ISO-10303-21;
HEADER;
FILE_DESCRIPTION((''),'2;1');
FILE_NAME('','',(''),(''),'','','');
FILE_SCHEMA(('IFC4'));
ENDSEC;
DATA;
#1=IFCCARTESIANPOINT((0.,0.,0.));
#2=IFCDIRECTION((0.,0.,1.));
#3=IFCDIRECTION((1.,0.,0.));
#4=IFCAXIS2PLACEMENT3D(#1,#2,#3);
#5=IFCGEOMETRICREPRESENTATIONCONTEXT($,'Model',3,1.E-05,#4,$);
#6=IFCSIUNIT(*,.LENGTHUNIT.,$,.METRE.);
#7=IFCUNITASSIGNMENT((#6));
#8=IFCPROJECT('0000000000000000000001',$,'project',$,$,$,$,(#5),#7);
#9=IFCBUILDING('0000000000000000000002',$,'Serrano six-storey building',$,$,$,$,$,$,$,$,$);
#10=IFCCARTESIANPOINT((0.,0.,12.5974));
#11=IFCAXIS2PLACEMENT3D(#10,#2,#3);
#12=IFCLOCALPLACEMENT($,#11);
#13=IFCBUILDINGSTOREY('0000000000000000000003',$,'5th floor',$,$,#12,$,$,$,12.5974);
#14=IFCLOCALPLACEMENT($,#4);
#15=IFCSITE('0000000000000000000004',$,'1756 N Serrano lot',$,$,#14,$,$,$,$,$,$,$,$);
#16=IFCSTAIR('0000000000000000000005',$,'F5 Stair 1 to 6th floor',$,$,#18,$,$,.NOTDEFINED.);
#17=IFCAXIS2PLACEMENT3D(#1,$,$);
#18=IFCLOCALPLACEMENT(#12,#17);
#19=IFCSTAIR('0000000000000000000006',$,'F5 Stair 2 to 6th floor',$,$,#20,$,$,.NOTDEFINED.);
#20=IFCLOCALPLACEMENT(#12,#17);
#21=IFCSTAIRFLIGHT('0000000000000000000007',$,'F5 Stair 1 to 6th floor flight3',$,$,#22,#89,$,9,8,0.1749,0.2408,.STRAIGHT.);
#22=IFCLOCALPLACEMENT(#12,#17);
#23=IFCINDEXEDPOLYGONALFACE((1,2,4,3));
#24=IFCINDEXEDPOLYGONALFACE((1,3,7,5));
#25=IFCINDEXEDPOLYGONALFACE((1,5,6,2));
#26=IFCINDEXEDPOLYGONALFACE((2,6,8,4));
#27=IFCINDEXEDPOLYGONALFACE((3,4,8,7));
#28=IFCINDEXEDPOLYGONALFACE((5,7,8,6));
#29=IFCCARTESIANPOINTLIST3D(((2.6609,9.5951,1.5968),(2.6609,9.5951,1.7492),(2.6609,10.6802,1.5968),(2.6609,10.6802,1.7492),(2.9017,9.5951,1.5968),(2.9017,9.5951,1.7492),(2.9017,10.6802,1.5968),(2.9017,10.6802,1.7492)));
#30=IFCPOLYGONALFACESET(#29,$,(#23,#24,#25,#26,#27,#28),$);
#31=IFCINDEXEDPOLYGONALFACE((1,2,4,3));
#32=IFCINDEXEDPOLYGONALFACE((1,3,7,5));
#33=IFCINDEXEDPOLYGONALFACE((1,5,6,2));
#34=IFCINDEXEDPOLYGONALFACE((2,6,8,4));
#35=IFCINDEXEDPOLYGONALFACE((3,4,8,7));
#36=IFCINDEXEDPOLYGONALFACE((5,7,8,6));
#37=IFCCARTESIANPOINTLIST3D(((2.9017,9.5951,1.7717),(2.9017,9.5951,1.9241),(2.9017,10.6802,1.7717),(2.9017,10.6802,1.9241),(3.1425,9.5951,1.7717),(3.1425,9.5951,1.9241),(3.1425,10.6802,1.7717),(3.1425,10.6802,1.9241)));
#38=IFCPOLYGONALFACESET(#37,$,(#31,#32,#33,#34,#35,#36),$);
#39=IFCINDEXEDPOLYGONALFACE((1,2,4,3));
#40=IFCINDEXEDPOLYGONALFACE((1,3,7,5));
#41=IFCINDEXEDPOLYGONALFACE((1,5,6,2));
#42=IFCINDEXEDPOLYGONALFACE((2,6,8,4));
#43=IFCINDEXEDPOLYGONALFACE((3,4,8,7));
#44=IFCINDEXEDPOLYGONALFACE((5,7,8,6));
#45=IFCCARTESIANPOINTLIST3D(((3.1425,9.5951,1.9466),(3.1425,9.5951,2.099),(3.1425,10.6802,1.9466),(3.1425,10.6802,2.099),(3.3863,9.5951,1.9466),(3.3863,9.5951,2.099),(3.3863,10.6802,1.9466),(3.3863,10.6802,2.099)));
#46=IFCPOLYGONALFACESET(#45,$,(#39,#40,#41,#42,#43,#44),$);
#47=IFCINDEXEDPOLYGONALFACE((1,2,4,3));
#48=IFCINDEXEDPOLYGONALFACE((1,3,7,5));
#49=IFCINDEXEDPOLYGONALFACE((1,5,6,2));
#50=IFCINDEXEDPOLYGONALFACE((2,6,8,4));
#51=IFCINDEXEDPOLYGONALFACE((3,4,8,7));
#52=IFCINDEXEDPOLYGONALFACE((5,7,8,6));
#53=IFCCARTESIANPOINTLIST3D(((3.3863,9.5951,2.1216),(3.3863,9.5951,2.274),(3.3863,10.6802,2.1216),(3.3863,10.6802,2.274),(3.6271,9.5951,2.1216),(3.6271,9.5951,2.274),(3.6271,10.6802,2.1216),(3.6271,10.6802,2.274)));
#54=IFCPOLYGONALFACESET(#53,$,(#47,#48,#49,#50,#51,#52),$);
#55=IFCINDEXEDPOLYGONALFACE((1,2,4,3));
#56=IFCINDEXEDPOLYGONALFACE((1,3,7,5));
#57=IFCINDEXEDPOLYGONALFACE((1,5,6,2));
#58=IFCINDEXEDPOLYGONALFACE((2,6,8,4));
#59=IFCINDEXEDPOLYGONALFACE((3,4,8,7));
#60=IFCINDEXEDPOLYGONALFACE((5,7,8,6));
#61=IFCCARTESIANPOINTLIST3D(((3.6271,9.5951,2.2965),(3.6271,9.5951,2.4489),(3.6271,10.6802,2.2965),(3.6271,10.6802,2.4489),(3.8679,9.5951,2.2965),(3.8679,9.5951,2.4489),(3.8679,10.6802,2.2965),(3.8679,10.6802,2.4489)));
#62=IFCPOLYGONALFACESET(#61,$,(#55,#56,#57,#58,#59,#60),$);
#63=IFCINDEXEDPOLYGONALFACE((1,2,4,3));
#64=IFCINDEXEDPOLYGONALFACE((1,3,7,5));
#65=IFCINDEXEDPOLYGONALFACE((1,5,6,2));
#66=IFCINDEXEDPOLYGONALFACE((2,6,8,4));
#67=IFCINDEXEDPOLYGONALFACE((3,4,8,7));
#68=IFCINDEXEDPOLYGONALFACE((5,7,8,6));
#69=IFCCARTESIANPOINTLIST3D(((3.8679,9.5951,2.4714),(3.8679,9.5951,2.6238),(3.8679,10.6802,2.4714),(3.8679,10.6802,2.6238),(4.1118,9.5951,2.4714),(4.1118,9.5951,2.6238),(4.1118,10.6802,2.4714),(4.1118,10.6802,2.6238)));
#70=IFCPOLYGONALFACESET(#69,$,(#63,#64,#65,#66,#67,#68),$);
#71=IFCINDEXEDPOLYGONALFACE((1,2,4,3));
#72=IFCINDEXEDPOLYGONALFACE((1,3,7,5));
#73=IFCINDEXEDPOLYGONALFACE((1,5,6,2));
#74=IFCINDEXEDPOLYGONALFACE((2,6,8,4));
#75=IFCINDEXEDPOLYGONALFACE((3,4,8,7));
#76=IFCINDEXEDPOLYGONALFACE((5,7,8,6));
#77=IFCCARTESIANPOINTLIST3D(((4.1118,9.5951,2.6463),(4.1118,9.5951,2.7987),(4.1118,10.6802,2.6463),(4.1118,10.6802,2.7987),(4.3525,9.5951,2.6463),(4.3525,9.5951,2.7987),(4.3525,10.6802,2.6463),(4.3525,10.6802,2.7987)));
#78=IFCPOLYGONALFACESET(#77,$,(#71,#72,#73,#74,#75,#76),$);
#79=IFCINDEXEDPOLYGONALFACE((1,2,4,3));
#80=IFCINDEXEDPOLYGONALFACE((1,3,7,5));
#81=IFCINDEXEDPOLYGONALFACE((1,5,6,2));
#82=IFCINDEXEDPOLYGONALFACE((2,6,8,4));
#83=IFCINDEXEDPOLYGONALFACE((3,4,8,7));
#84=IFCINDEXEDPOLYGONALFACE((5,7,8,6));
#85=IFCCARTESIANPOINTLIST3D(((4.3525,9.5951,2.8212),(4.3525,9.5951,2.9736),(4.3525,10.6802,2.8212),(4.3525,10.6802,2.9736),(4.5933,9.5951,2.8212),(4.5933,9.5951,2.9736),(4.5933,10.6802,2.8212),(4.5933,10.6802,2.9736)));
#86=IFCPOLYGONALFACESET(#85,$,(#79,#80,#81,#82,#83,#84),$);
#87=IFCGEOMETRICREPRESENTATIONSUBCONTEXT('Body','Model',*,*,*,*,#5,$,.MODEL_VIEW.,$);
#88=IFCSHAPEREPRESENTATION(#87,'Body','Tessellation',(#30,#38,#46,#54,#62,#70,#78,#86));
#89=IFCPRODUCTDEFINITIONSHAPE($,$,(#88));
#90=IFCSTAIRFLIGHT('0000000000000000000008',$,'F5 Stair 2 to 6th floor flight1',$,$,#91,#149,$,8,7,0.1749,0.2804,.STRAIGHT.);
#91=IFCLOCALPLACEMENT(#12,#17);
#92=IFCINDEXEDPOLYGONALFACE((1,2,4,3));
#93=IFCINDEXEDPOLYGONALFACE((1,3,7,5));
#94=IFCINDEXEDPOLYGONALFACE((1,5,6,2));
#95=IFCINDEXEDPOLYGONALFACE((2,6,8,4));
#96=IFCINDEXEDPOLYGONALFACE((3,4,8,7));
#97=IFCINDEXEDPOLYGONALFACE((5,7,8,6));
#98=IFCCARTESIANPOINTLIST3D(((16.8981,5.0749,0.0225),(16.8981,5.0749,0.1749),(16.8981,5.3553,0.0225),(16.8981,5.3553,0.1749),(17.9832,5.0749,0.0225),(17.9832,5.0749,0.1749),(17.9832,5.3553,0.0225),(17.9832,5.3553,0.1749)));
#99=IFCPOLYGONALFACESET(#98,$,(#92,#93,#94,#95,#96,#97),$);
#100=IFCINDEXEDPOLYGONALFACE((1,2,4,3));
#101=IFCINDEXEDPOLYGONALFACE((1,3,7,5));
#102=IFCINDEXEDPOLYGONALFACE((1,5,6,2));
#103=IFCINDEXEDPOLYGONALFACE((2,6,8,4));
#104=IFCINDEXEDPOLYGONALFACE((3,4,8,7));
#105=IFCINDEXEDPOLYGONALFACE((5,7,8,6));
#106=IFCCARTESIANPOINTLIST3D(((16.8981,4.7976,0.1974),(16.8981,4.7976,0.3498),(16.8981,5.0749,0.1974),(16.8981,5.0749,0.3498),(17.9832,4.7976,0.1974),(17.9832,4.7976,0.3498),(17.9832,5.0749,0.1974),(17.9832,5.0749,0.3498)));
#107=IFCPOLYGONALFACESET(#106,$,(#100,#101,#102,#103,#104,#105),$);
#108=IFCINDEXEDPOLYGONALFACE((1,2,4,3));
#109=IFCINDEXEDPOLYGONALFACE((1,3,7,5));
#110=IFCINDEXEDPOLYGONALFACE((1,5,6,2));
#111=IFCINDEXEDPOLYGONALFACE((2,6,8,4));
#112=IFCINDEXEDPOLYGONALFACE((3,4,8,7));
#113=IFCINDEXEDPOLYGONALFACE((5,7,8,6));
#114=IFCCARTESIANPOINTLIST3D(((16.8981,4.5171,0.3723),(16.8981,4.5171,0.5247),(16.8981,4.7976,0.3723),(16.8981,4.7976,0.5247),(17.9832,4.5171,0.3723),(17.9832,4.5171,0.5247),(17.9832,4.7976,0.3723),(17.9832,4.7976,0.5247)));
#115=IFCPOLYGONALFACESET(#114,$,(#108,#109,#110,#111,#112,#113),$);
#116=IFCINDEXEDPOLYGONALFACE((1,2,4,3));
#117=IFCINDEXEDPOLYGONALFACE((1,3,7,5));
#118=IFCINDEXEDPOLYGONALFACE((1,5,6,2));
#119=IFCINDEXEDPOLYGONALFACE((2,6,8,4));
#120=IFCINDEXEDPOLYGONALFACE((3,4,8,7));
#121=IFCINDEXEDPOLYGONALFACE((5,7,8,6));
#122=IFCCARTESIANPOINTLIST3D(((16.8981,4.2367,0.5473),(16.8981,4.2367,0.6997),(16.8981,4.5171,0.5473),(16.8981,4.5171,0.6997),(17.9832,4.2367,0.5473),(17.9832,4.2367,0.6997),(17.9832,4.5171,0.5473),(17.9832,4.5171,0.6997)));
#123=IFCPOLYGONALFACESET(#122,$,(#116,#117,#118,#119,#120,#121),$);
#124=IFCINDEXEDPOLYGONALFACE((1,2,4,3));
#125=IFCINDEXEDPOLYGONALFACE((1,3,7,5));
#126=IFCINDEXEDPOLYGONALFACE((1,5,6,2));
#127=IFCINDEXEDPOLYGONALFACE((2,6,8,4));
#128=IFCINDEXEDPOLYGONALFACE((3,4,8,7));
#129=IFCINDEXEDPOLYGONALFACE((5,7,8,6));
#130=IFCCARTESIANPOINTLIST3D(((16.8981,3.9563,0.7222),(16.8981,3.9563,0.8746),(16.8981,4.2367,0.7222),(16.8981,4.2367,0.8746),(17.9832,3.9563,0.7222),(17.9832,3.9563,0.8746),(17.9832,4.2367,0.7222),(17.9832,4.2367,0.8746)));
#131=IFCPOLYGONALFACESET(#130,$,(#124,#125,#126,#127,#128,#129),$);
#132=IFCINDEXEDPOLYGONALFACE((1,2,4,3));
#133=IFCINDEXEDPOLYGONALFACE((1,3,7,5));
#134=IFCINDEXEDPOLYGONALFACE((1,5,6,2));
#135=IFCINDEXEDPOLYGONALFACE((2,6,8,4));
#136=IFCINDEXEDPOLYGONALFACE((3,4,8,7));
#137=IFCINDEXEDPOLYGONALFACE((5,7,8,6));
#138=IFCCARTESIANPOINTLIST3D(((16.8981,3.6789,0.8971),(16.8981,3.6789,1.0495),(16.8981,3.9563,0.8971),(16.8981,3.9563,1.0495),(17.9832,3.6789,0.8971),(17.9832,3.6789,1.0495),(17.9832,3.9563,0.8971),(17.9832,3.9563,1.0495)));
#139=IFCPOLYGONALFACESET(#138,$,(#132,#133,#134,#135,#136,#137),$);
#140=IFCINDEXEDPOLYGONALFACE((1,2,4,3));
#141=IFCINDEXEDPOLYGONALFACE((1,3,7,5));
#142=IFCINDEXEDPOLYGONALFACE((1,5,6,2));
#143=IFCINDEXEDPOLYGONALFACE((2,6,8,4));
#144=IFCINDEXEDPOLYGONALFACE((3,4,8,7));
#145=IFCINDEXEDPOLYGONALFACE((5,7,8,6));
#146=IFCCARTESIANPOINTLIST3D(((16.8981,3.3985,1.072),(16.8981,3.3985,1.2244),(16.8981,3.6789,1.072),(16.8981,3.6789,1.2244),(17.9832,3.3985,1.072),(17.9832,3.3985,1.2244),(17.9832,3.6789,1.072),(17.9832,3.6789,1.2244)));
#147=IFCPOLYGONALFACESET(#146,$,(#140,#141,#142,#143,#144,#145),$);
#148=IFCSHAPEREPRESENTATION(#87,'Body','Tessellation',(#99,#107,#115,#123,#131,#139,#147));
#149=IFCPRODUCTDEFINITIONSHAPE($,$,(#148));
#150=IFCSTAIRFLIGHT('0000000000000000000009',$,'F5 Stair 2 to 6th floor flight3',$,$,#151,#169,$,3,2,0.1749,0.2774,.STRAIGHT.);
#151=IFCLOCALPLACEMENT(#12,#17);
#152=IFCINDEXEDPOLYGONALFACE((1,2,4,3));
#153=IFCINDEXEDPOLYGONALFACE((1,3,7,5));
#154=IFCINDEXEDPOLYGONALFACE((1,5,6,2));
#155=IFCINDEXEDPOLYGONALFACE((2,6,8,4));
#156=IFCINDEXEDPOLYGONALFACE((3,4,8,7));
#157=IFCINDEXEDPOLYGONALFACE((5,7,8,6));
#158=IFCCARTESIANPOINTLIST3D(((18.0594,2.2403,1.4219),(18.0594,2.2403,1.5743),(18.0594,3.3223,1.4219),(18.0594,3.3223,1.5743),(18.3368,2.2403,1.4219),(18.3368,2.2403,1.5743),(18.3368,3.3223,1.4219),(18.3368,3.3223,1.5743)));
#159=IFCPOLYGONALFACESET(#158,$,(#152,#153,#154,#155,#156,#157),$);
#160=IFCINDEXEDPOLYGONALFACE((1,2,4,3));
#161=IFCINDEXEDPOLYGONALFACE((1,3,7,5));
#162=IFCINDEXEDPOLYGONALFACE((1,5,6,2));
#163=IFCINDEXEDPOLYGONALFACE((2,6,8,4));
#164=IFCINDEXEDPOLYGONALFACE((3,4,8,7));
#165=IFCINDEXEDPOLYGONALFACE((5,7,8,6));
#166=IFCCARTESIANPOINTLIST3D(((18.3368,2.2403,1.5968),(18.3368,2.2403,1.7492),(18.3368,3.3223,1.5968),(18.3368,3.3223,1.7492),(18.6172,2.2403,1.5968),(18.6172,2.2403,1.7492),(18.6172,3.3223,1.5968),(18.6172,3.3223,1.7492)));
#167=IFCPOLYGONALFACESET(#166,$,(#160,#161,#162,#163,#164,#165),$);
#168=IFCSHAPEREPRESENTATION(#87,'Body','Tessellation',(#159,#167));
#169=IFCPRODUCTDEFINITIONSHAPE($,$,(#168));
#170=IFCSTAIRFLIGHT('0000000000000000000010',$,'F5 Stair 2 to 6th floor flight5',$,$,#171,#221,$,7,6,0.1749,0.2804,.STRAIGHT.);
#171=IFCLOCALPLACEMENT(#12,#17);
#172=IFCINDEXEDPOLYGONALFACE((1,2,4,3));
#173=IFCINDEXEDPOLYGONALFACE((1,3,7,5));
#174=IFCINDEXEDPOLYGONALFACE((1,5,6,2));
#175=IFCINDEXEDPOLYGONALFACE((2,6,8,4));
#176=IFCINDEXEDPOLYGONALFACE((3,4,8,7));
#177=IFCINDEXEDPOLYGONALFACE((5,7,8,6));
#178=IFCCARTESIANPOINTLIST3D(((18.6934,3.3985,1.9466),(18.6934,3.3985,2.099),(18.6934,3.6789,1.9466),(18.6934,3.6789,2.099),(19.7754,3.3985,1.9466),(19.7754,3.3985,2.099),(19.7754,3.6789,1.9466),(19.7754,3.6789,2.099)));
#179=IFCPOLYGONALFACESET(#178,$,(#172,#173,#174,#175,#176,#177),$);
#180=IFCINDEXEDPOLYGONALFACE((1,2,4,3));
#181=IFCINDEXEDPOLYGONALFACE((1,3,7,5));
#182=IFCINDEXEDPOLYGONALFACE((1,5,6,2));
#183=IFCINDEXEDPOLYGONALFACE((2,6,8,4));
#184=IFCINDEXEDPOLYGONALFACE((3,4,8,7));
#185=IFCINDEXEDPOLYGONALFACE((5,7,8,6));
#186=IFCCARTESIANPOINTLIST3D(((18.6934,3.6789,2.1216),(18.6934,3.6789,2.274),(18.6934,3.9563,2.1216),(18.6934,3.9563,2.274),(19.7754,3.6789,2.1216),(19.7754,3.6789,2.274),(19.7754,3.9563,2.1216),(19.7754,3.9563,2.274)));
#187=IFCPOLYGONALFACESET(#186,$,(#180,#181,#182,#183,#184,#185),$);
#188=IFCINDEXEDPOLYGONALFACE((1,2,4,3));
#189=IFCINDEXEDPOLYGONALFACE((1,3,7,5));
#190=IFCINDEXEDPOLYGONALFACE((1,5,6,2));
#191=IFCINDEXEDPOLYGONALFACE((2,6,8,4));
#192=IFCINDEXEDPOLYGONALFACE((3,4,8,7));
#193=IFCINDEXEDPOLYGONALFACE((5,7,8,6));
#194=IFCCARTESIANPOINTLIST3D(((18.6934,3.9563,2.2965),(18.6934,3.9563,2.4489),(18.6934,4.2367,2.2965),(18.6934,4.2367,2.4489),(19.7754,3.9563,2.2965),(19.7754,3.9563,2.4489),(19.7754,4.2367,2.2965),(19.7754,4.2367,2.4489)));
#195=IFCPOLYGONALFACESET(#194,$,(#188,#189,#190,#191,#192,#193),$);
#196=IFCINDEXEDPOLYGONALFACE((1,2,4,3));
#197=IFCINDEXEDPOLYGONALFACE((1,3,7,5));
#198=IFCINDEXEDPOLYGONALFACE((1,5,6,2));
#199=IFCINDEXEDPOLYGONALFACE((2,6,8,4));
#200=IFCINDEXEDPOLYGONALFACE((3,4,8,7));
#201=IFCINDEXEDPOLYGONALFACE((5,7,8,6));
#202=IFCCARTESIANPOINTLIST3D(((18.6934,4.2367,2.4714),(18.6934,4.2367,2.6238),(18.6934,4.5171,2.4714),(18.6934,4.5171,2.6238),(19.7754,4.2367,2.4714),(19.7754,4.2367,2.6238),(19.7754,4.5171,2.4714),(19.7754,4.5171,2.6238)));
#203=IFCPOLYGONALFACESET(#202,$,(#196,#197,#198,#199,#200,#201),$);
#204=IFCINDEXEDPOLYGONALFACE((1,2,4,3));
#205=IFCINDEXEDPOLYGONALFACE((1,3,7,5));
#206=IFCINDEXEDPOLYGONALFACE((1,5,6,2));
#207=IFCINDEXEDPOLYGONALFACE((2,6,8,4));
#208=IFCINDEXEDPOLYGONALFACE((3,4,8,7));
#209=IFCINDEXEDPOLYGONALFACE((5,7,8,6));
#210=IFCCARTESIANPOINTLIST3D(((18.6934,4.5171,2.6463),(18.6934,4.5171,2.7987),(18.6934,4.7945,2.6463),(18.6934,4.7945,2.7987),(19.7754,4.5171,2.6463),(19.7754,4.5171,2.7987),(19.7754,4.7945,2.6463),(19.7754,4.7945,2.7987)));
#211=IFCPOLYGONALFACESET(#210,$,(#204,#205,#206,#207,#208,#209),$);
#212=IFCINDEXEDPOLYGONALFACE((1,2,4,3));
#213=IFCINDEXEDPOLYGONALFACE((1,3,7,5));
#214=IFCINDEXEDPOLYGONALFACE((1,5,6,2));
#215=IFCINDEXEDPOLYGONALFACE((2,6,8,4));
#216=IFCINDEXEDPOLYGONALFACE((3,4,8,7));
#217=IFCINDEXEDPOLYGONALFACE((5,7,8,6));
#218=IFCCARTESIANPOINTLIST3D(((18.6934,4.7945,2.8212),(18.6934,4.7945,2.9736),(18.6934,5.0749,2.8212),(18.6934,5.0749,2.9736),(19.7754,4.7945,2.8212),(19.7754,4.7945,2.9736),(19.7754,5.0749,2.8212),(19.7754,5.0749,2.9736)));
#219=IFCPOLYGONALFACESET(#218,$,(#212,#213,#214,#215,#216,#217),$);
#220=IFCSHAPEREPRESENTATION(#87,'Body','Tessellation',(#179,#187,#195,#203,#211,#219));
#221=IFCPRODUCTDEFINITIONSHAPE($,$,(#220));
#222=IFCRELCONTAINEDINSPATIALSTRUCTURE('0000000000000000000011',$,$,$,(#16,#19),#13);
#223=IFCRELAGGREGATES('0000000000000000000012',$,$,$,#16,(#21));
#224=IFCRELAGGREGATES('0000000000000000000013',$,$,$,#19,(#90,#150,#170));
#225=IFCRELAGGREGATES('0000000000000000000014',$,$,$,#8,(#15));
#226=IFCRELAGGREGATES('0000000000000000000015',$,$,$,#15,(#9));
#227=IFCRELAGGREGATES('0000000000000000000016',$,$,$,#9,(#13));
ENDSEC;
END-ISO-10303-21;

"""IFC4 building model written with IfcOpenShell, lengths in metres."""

from ifc_helpers import new_model, si_unit, frame, origin_with_axes, place, context, subcontext, project, spatial, polyline, outline, extrude, element, aggregate, save


model = new_model("IFC4")

# Units and contexts
model_context = context("Model", 3, precision=1e-05, world=origin_with_axes())
body_context = subcontext(model_context, "Body", "Model", "MODEL_VIEW")
ifc_project = project(units=[si_unit("LENGTHUNIT", "METRE")], contexts=[model_context])

# Site, building, storey
site_placement = place(None, origin_with_axes())
site = spatial("IfcSite", under=ifc_project, at=site_placement, Name="1756 N Serrano lot")
building = spatial("IfcBuilding", under=site, Name="Serrano six-storey building")
storey_placement = place(None, frame((0.0, 0.0, 12.5974), z_axis=(0.0, 0.0, 1.0), x_axis=(1.0, 0.0, 0.0)))
storey = spatial("IfcBuildingStorey", under=building, at=storey_placement, Name="5th floor", Elevation=12.5974)

# Stair
stair_1 = element("IfcStair", 1, inside=storey, Name="F5 Stair 1 to 6th floor", PredefinedType="NOTDEFINED")

# Stair
stair_2 = element("IfcStair", 2, inside=storey, Name="F5 Stair 2 to 6th floor", PredefinedType="NOTDEFINED")

# Stair flights
stair_flight_1_placement = place(None, origin_with_axes())
stair_flight_1 = element("IfcStairFlight", 3, at=stair_flight_1_placement, Name="F5 Stair 1 to 6th floor flight3", NumberOfRisers=9, NumberOfTreads=8, PredefinedType="STRAIGHT", RiserHeight=0.1749, TreadLength=0.2408, context=body_context, shape_type="SweptSolid", body=[
    extrude(outline(polyline([(2.9017, 9.5951), (2.9017, 10.6802), (2.6609, 10.6802), (2.6609, 9.5951), (2.9017, 9.5951)])), frame((0.0, 0.0, 14.1942)), (0.0, 0.0, 1.0), 0.1524),
    extrude(outline(polyline([(3.1425, 9.5951), (3.1425, 10.6802), (2.9017, 10.6802), (2.9017, 9.5951), (3.1425, 9.5951)])), frame((0.0, 0.0, 14.3691)), (0.0, 0.0, 1.0), 0.1524),
    extrude(outline(polyline([(3.3863, 9.5951), (3.3863, 10.6802), (3.1425, 10.6802), (3.1425, 9.5951), (3.3863, 9.5951)])), frame((0.0, 0.0, 14.544)), (0.0, 0.0, 1.0), 0.1524),
    extrude(outline(polyline([(3.6271, 9.5951), (3.6271, 10.6802), (3.3863, 10.6802), (3.3863, 9.5951), (3.6271, 9.5951)])), frame((0.0, 0.0, 14.719)), (0.0, 0.0, 1.0), 0.1524),
    extrude(outline(polyline([(3.8679, 9.5951), (3.8679, 10.6802), (3.6271, 10.6802), (3.6271, 9.5951), (3.8679, 9.5951)])), frame((0.0, 0.0, 14.8939)), (0.0, 0.0, 1.0), 0.1524),
    extrude(outline(polyline([(4.1118, 9.5951), (4.1118, 10.6802), (3.8679, 10.6802), (3.8679, 9.5951), (4.1118, 9.5951)])), frame((0.0, 0.0, 15.0688)), (0.0, 0.0, 1.0), 0.1524),
    extrude(outline(polyline([(4.3525, 9.5951), (4.3525, 10.6802), (4.1118, 10.6802), (4.1118, 9.5951), (4.3525, 9.5951)])), frame((0.0, 0.0, 15.2437)), (0.0, 0.0, 1.0), 0.1524),
    extrude(outline(polyline([(4.5933, 9.5951), (4.5933, 10.6802), (4.3525, 10.6802), (4.3525, 9.5951), (4.5933, 9.5951)])), frame((0.0, 0.0, 15.4186)), (0.0, 0.0, 1.0), 0.1524),
])
aggregate(stair_1, [stair_flight_1])
stair_flight_2_placement = place(None, origin_with_axes())
stair_flight_2 = element("IfcStairFlight", 4, at=stair_flight_2_placement, Name="F5 Stair 2 to 6th floor flight1", NumberOfRisers=8, NumberOfTreads=7, PredefinedType="STRAIGHT", RiserHeight=0.1749, TreadLength=0.2804, context=body_context, shape_type="SweptSolid", body=[
    extrude(outline(polyline([(17.9832, 5.0749), (17.9832, 5.3553), (16.8981, 5.3553), (16.8981, 5.0749), (17.9832, 5.0749)])), frame((0.0, 0.0, 12.6199)), (0.0, 0.0, 1.0), 0.1524),
    extrude(outline(polyline([(17.9832, 4.7976), (17.9832, 5.0749), (16.8981, 5.0749), (16.8981, 4.7976), (17.9832, 4.7976)])), frame((0.0, 0.0, 12.7948)), (0.0, 0.0, 1.0), 0.1524),
    extrude(outline(polyline([(17.9832, 4.5171), (17.9832, 4.7976), (16.8981, 4.7976), (16.8981, 4.5171), (17.9832, 4.5171)])), frame((0.0, 0.0, 12.9697)), (0.0, 0.0, 1.0), 0.1524),
    extrude(outline(polyline([(17.9832, 4.2367), (17.9832, 4.5171), (16.8981, 4.5171), (16.8981, 4.2367), (17.9832, 4.2367)])), frame((0.0, 0.0, 13.1447)), (0.0, 0.0, 1.0), 0.1524),
    extrude(outline(polyline([(17.9832, 3.9563), (17.9832, 4.2367), (16.8981, 4.2367), (16.8981, 3.9563), (17.9832, 3.9563)])), frame((0.0, 0.0, 13.3196)), (0.0, 0.0, 1.0), 0.1524),
    extrude(outline(polyline([(17.9832, 3.6789), (17.9832, 3.9563), (16.8981, 3.9563), (16.8981, 3.6789), (17.9832, 3.6789)])), frame((0.0, 0.0, 13.4945)), (0.0, 0.0, 1.0), 0.1524),
    extrude(outline(polyline([(17.9832, 3.3985), (17.9832, 3.6789), (16.8981, 3.6789), (16.8981, 3.3985), (17.9832, 3.3985)])), frame((0.0, 0.0, 13.6694)), (0.0, 0.0, 1.0), 0.1524),
])
stair_flight_3_placement = place(None, origin_with_axes())
stair_flight_3 = element("IfcStairFlight", 5, at=stair_flight_3_placement, Name="F5 Stair 2 to 6th floor flight3", NumberOfRisers=3, NumberOfTreads=2, PredefinedType="STRAIGHT", RiserHeight=0.1749, TreadLength=0.2774, context=body_context, shape_type="SweptSolid", body=[
    extrude(outline(polyline([(18.3368, 2.2403), (18.3368, 3.3223), (18.0594, 3.3223), (18.0594, 2.2403), (18.3368, 2.2403)])), frame((0.0, 0.0, 14.0193)), (0.0, 0.0, 1.0), 0.1524),
    extrude(outline(polyline([(18.6172, 2.2403), (18.6172, 3.3223), (18.3368, 3.3223), (18.3368, 2.2403), (18.6172, 2.2403)])), frame((0.0, 0.0, 14.1942)), (0.0, 0.0, 1.0), 0.1524),
])
stair_flight_4_placement = place(None, origin_with_axes())
stair_flight_4 = element("IfcStairFlight", 6, at=stair_flight_4_placement, Name="F5 Stair 2 to 6th floor flight5", NumberOfRisers=7, NumberOfTreads=6, PredefinedType="STRAIGHT", RiserHeight=0.1749, TreadLength=0.2804, context=body_context, shape_type="SweptSolid", body=[
    extrude(outline(polyline([(19.7754, 3.3985), (19.7754, 3.6789), (18.6934, 3.6789), (18.6934, 3.3985), (19.7754, 3.3985)])), frame((0.0, 0.0, 14.544)), (0.0, 0.0, 1.0), 0.1524),
    extrude(outline(polyline([(19.7754, 3.6789), (19.7754, 3.9563), (18.6934, 3.9563), (18.6934, 3.6789), (19.7754, 3.6789)])), frame((0.0, 0.0, 14.719)), (0.0, 0.0, 1.0), 0.1524),
    extrude(outline(polyline([(19.7754, 3.9563), (19.7754, 4.2367), (18.6934, 4.2367), (18.6934, 3.9563), (19.7754, 3.9563)])), frame((0.0, 0.0, 14.8939)), (0.0, 0.0, 1.0), 0.1524),
    extrude(outline(polyline([(19.7754, 4.2367), (19.7754, 4.5171), (18.6934, 4.5171), (18.6934, 4.2367), (19.7754, 4.2367)])), frame((0.0, 0.0, 15.0688)), (0.0, 0.0, 1.0), 0.1524),
    extrude(outline(polyline([(19.7754, 4.5171), (19.7754, 4.7945), (18.6934, 4.7945), (18.6934, 4.5171), (19.7754, 4.5171)])), frame((0.0, 0.0, 15.2437)), (0.0, 0.0, 1.0), 0.1524),
    extrude(outline(polyline([(19.7754, 4.7945), (19.7754, 5.0749), (18.6934, 5.0749), (18.6934, 4.7945), (19.7754, 4.7945)])), frame((0.0, 0.0, 15.4186)), (0.0, 0.0, 1.0), 0.1524),
])
aggregate(stair_2, [stair_flight_2, stair_flight_3, stair_flight_4])

save(model, "model.ifc")
